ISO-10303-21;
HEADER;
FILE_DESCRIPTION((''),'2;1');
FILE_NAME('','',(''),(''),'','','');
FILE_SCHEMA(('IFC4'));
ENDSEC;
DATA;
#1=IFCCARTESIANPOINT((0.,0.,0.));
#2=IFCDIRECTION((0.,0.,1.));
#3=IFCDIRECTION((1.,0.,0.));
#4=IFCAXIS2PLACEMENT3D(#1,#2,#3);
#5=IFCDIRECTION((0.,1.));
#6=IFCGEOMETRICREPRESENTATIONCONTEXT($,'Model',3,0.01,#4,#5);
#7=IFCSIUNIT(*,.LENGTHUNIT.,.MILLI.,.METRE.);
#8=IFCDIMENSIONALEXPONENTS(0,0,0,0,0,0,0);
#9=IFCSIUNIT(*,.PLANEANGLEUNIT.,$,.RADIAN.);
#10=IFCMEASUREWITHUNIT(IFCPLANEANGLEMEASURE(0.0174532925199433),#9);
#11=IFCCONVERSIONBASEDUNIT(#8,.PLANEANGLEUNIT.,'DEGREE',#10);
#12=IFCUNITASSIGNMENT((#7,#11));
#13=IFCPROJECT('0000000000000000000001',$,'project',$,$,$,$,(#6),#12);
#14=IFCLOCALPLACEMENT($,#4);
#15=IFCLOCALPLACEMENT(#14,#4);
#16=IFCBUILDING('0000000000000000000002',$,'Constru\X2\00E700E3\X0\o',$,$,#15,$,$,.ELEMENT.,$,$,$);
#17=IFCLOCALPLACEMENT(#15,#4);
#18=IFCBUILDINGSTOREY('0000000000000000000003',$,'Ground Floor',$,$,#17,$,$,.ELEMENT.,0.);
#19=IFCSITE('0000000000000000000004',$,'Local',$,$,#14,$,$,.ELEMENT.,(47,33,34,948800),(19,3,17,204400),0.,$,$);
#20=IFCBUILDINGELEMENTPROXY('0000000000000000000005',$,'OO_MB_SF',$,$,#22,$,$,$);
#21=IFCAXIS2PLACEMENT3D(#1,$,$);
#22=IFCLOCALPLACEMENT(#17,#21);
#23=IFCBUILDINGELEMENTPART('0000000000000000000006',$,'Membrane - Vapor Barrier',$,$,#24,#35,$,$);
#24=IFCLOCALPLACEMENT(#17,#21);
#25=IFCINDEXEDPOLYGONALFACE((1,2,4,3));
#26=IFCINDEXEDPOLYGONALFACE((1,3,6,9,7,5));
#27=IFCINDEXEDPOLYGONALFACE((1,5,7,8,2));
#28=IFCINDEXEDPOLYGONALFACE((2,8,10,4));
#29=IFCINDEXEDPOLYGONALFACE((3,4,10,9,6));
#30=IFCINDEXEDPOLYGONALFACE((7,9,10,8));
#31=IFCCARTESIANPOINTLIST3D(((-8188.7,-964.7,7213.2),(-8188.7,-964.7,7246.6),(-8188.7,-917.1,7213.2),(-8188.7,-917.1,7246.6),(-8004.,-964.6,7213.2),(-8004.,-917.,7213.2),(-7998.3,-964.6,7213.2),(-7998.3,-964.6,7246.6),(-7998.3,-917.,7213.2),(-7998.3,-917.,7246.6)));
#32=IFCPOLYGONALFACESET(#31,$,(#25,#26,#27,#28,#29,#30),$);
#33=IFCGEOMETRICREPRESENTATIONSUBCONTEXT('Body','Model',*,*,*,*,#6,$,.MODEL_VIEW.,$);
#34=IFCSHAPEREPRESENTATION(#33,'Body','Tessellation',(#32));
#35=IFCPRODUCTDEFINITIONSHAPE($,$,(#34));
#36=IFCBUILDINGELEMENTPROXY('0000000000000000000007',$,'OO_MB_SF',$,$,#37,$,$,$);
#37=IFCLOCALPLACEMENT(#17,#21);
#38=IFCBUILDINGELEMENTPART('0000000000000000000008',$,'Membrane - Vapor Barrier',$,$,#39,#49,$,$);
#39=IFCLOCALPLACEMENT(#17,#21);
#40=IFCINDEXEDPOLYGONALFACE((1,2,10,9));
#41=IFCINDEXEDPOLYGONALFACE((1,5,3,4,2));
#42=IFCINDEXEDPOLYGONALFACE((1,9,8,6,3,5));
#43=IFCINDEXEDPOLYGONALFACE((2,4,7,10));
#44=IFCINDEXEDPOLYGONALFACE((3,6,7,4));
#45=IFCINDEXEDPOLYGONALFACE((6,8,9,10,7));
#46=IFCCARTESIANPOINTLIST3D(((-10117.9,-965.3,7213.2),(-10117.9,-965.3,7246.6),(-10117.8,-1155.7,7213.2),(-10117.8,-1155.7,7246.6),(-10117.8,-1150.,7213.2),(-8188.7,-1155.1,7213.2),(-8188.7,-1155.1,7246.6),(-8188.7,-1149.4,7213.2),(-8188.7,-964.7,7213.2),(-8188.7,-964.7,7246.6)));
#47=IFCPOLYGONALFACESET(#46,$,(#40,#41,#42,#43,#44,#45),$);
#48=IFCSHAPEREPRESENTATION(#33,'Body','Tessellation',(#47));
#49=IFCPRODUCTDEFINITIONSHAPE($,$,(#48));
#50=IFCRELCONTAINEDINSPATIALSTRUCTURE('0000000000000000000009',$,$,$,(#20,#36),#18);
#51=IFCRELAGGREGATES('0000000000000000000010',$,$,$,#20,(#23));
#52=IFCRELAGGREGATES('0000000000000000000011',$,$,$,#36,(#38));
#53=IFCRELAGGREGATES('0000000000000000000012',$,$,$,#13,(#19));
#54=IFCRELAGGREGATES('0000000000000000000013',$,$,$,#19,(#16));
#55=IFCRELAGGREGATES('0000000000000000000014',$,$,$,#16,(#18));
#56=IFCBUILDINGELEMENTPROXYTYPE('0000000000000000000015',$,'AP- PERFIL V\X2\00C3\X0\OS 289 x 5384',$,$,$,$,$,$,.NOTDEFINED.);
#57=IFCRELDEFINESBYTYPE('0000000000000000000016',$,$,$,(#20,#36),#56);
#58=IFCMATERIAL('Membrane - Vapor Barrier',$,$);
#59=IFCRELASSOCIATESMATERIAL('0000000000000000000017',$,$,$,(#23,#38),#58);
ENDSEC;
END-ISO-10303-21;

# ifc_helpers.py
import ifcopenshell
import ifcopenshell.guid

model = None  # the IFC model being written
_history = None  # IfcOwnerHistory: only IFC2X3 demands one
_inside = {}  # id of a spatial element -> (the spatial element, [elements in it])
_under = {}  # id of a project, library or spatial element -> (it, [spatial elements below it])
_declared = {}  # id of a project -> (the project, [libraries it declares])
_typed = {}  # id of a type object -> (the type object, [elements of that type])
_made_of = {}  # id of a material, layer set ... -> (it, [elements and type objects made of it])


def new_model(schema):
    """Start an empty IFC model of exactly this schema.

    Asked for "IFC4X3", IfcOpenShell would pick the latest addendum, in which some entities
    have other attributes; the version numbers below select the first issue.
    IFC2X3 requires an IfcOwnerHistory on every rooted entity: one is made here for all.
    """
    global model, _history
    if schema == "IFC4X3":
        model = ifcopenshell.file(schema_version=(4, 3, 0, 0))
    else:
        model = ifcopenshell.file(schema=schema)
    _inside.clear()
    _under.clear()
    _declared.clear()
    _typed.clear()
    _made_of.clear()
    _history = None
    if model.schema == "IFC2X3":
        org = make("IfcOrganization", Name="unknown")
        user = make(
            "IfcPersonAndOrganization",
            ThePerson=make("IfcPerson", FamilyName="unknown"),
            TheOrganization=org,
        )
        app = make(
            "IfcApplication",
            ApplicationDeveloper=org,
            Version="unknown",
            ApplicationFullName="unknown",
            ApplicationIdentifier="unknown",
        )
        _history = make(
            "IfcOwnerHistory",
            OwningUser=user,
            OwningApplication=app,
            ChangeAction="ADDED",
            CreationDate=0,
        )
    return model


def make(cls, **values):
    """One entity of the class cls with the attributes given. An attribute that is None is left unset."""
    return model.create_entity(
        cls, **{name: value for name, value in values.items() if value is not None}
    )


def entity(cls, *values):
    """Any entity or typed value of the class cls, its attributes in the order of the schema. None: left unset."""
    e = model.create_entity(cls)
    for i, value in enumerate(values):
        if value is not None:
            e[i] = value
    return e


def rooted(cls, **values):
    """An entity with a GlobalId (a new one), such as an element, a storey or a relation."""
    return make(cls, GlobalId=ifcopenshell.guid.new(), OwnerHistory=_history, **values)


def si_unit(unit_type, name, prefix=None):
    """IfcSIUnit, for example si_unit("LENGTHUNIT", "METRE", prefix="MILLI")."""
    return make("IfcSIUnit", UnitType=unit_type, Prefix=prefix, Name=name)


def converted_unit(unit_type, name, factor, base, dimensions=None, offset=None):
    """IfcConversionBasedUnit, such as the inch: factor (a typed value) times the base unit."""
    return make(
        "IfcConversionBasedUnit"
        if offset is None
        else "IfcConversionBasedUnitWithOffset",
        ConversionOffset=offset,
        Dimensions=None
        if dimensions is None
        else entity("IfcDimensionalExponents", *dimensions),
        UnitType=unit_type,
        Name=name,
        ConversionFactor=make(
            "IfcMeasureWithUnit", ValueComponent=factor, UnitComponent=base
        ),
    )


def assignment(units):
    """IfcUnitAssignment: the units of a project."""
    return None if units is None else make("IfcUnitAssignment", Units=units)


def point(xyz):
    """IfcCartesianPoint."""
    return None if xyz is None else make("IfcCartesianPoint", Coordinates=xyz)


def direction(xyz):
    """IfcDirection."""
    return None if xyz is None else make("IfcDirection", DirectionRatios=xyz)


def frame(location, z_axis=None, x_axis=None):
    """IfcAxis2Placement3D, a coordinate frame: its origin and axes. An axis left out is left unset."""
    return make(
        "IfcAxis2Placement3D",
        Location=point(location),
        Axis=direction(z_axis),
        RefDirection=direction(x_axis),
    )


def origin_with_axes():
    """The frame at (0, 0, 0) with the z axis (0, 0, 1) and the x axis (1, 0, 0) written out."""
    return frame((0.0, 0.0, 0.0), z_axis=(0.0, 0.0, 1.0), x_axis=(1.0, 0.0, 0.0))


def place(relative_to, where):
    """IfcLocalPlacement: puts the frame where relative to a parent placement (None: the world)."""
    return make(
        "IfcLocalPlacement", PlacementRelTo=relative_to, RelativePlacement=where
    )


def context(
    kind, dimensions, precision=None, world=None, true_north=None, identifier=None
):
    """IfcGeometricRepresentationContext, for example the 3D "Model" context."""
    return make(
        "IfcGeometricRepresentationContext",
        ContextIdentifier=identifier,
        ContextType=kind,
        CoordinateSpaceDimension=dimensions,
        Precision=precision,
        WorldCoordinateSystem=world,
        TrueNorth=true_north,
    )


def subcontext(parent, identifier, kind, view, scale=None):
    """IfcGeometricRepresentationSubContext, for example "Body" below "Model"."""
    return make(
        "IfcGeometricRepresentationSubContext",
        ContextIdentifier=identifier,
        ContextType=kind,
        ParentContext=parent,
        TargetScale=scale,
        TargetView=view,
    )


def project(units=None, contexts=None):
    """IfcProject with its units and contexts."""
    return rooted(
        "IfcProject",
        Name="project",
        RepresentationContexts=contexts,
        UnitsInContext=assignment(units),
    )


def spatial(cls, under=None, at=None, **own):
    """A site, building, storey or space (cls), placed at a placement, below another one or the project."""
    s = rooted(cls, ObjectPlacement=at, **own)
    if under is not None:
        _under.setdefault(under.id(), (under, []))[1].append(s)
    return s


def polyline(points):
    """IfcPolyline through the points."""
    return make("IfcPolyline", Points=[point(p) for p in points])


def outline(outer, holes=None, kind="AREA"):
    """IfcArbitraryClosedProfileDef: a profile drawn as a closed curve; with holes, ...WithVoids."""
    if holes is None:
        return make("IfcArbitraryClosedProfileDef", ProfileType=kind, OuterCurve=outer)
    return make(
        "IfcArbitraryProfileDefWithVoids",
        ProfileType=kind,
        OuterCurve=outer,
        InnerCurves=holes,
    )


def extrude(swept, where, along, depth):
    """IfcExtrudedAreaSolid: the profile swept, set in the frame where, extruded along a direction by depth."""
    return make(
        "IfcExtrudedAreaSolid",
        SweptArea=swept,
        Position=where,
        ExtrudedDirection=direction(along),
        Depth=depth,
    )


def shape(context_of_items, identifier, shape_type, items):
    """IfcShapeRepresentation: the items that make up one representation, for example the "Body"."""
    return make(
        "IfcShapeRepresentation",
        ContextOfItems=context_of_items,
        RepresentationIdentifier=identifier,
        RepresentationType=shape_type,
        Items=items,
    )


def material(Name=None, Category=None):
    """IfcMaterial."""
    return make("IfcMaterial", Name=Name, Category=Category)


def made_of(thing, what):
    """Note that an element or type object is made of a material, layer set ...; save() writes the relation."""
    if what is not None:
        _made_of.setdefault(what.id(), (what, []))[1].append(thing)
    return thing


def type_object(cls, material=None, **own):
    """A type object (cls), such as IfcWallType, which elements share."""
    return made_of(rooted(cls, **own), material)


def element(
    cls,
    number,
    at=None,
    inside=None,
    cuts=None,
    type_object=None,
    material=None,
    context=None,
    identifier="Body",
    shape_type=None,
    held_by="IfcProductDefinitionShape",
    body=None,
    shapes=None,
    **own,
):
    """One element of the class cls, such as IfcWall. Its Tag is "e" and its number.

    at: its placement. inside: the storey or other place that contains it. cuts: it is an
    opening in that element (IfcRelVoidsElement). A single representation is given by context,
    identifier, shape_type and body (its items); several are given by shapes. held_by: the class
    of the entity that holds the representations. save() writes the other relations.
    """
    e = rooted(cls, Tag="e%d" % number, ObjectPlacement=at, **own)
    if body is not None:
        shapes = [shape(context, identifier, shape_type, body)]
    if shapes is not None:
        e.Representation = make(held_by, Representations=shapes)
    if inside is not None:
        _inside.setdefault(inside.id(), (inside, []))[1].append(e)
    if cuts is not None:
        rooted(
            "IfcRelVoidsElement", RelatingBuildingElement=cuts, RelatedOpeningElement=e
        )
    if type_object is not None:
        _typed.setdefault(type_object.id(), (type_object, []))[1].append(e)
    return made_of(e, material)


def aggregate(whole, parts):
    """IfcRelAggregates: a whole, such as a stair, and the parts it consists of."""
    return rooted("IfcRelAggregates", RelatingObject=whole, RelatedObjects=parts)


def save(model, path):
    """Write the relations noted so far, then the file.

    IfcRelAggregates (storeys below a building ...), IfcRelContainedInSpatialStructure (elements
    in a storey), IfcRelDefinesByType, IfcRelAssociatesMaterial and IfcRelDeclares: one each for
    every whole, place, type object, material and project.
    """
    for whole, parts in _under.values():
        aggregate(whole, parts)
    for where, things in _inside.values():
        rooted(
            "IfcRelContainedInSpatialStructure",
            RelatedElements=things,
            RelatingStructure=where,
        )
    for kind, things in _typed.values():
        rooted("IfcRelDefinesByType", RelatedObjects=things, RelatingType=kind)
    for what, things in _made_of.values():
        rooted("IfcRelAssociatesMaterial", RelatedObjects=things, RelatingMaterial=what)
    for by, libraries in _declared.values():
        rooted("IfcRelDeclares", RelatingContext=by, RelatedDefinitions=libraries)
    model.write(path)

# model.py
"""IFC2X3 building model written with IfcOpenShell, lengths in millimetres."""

from ifc_helpers import new_model, entity, si_unit, converted_unit, direction, frame, origin_with_axes, place, context, subcontext, project, spatial, polyline, outline, extrude, material, type_object, element, aggregate, save


model = new_model("IFC2X3")

# Units and contexts
model_context = context("Model", 3, precision=0.01, world=origin_with_axes(), true_north=direction((0.0, 1.0)))
body_context = subcontext(model_context, "Body", "Model", "MODEL_VIEW")
ifc_project = project(units=[si_unit("LENGTHUNIT", "METRE", prefix="MILLI"), converted_unit("PLANEANGLEUNIT", "DEGREE", entity("IfcPlaneAngleMeasure", 0.0174532925199433), si_unit("PLANEANGLEUNIT", "RADIAN"), dimensions=[0, 0, 0, 0, 0, 0, 0])], contexts=[model_context])

# Site, building, storey
site_placement = place(None, origin_with_axes())
site = spatial("IfcSite", under=ifc_project, at=site_placement, Name="Local", CompositionType="ELEMENT", RefLatitude=(47, 33, 34, 948800), RefLongitude=(19, 3, 17, 204400), RefElevation=0.0)
building_placement = place(site_placement, origin_with_axes())
building = spatial("IfcBuilding", under=site, at=building_placement, Name="Construção", CompositionType="ELEMENT")
storey_placement = place(building_placement, origin_with_axes())
storey = spatial("IfcBuildingStorey", under=building, at=storey_placement, Name="Ground Floor", CompositionType="ELEMENT", Elevation=0.0)

# Building element proxies, building element parts
building_element_proxy_type = type_object("IfcBuildingElementProxyType", Name="AP- PERFIL VÃOS 289 x 5384", PredefinedType="NOTDEFINED")
proxy_1_placement = place(storey_placement, frame((-8188.7, -964.7, 7246.6), z_axis=(0.0, 0.0, 1.0), x_axis=(1.0, 0.000322, 0.0)))
proxy_1 = element("IfcBuildingElementProxy", 1, at=proxy_1_placement, inside=storey, type_object=building_element_proxy_type, Name="OO_MB_SF")
ifc_material = material(Name="Membrane - Vapor Barrier")
building_element_part_1_placement = place(proxy_1_placement, origin_with_axes())
building_element_part_1 = element("IfcBuildingElementPart", 2, at=building_element_part_1_placement, material=ifc_material, Name="Membrane - Vapor Barrier", context=body_context, shape_type="SweptSolid", body=[
    extrude(outline(polyline([(190.4, 0.0), (0.0, 0.0), (0.0, -33.3), (184.7, -33.3), (190.4, -33.3), (190.4, 0.0)])), frame((0.0, 47.6, 0.0), z_axis=(0.0, -1.0, 0.0), x_axis=(1.0, 0.0, 0.0)), (0.0, 0.0, 1.0), 47.6),
])
aggregate(proxy_1, [building_element_part_1])
proxy_2_placement = place(storey_placement, frame((-10117.9, -965.3, 7246.6), z_axis=(0.0, 0.0, 1.0), x_axis=(0.000322, -1.0, 0.0)))
proxy_2 = element("IfcBuildingElementProxy", 3, at=proxy_2_placement, inside=storey, type_object=building_element_proxy_type, Name="OO_MB_SF")
building_element_part_2_placement = place(proxy_2_placement, origin_with_axes())
building_element_part_2 = element("IfcBuildingElementPart", 4, at=building_element_part_2_placement, material=ifc_material, Name="Membrane - Vapor Barrier", context=body_context, shape_type="SweptSolid", body=[
    extrude(outline(polyline([(190.4, 0.0), (0.0, 0.0), (0.0, -33.3), (184.7, -33.3), (190.4, -33.3), (190.4, 0.0)])), frame((0.0, 1929.2, 0.0), z_axis=(0.0, -1.0, 0.0), x_axis=(1.0, 0.0, 0.0)), (0.0, 0.0, 1.0), 1929.2),
])
aggregate(proxy_2, [building_element_part_2])

save(model, "model.ifc")
